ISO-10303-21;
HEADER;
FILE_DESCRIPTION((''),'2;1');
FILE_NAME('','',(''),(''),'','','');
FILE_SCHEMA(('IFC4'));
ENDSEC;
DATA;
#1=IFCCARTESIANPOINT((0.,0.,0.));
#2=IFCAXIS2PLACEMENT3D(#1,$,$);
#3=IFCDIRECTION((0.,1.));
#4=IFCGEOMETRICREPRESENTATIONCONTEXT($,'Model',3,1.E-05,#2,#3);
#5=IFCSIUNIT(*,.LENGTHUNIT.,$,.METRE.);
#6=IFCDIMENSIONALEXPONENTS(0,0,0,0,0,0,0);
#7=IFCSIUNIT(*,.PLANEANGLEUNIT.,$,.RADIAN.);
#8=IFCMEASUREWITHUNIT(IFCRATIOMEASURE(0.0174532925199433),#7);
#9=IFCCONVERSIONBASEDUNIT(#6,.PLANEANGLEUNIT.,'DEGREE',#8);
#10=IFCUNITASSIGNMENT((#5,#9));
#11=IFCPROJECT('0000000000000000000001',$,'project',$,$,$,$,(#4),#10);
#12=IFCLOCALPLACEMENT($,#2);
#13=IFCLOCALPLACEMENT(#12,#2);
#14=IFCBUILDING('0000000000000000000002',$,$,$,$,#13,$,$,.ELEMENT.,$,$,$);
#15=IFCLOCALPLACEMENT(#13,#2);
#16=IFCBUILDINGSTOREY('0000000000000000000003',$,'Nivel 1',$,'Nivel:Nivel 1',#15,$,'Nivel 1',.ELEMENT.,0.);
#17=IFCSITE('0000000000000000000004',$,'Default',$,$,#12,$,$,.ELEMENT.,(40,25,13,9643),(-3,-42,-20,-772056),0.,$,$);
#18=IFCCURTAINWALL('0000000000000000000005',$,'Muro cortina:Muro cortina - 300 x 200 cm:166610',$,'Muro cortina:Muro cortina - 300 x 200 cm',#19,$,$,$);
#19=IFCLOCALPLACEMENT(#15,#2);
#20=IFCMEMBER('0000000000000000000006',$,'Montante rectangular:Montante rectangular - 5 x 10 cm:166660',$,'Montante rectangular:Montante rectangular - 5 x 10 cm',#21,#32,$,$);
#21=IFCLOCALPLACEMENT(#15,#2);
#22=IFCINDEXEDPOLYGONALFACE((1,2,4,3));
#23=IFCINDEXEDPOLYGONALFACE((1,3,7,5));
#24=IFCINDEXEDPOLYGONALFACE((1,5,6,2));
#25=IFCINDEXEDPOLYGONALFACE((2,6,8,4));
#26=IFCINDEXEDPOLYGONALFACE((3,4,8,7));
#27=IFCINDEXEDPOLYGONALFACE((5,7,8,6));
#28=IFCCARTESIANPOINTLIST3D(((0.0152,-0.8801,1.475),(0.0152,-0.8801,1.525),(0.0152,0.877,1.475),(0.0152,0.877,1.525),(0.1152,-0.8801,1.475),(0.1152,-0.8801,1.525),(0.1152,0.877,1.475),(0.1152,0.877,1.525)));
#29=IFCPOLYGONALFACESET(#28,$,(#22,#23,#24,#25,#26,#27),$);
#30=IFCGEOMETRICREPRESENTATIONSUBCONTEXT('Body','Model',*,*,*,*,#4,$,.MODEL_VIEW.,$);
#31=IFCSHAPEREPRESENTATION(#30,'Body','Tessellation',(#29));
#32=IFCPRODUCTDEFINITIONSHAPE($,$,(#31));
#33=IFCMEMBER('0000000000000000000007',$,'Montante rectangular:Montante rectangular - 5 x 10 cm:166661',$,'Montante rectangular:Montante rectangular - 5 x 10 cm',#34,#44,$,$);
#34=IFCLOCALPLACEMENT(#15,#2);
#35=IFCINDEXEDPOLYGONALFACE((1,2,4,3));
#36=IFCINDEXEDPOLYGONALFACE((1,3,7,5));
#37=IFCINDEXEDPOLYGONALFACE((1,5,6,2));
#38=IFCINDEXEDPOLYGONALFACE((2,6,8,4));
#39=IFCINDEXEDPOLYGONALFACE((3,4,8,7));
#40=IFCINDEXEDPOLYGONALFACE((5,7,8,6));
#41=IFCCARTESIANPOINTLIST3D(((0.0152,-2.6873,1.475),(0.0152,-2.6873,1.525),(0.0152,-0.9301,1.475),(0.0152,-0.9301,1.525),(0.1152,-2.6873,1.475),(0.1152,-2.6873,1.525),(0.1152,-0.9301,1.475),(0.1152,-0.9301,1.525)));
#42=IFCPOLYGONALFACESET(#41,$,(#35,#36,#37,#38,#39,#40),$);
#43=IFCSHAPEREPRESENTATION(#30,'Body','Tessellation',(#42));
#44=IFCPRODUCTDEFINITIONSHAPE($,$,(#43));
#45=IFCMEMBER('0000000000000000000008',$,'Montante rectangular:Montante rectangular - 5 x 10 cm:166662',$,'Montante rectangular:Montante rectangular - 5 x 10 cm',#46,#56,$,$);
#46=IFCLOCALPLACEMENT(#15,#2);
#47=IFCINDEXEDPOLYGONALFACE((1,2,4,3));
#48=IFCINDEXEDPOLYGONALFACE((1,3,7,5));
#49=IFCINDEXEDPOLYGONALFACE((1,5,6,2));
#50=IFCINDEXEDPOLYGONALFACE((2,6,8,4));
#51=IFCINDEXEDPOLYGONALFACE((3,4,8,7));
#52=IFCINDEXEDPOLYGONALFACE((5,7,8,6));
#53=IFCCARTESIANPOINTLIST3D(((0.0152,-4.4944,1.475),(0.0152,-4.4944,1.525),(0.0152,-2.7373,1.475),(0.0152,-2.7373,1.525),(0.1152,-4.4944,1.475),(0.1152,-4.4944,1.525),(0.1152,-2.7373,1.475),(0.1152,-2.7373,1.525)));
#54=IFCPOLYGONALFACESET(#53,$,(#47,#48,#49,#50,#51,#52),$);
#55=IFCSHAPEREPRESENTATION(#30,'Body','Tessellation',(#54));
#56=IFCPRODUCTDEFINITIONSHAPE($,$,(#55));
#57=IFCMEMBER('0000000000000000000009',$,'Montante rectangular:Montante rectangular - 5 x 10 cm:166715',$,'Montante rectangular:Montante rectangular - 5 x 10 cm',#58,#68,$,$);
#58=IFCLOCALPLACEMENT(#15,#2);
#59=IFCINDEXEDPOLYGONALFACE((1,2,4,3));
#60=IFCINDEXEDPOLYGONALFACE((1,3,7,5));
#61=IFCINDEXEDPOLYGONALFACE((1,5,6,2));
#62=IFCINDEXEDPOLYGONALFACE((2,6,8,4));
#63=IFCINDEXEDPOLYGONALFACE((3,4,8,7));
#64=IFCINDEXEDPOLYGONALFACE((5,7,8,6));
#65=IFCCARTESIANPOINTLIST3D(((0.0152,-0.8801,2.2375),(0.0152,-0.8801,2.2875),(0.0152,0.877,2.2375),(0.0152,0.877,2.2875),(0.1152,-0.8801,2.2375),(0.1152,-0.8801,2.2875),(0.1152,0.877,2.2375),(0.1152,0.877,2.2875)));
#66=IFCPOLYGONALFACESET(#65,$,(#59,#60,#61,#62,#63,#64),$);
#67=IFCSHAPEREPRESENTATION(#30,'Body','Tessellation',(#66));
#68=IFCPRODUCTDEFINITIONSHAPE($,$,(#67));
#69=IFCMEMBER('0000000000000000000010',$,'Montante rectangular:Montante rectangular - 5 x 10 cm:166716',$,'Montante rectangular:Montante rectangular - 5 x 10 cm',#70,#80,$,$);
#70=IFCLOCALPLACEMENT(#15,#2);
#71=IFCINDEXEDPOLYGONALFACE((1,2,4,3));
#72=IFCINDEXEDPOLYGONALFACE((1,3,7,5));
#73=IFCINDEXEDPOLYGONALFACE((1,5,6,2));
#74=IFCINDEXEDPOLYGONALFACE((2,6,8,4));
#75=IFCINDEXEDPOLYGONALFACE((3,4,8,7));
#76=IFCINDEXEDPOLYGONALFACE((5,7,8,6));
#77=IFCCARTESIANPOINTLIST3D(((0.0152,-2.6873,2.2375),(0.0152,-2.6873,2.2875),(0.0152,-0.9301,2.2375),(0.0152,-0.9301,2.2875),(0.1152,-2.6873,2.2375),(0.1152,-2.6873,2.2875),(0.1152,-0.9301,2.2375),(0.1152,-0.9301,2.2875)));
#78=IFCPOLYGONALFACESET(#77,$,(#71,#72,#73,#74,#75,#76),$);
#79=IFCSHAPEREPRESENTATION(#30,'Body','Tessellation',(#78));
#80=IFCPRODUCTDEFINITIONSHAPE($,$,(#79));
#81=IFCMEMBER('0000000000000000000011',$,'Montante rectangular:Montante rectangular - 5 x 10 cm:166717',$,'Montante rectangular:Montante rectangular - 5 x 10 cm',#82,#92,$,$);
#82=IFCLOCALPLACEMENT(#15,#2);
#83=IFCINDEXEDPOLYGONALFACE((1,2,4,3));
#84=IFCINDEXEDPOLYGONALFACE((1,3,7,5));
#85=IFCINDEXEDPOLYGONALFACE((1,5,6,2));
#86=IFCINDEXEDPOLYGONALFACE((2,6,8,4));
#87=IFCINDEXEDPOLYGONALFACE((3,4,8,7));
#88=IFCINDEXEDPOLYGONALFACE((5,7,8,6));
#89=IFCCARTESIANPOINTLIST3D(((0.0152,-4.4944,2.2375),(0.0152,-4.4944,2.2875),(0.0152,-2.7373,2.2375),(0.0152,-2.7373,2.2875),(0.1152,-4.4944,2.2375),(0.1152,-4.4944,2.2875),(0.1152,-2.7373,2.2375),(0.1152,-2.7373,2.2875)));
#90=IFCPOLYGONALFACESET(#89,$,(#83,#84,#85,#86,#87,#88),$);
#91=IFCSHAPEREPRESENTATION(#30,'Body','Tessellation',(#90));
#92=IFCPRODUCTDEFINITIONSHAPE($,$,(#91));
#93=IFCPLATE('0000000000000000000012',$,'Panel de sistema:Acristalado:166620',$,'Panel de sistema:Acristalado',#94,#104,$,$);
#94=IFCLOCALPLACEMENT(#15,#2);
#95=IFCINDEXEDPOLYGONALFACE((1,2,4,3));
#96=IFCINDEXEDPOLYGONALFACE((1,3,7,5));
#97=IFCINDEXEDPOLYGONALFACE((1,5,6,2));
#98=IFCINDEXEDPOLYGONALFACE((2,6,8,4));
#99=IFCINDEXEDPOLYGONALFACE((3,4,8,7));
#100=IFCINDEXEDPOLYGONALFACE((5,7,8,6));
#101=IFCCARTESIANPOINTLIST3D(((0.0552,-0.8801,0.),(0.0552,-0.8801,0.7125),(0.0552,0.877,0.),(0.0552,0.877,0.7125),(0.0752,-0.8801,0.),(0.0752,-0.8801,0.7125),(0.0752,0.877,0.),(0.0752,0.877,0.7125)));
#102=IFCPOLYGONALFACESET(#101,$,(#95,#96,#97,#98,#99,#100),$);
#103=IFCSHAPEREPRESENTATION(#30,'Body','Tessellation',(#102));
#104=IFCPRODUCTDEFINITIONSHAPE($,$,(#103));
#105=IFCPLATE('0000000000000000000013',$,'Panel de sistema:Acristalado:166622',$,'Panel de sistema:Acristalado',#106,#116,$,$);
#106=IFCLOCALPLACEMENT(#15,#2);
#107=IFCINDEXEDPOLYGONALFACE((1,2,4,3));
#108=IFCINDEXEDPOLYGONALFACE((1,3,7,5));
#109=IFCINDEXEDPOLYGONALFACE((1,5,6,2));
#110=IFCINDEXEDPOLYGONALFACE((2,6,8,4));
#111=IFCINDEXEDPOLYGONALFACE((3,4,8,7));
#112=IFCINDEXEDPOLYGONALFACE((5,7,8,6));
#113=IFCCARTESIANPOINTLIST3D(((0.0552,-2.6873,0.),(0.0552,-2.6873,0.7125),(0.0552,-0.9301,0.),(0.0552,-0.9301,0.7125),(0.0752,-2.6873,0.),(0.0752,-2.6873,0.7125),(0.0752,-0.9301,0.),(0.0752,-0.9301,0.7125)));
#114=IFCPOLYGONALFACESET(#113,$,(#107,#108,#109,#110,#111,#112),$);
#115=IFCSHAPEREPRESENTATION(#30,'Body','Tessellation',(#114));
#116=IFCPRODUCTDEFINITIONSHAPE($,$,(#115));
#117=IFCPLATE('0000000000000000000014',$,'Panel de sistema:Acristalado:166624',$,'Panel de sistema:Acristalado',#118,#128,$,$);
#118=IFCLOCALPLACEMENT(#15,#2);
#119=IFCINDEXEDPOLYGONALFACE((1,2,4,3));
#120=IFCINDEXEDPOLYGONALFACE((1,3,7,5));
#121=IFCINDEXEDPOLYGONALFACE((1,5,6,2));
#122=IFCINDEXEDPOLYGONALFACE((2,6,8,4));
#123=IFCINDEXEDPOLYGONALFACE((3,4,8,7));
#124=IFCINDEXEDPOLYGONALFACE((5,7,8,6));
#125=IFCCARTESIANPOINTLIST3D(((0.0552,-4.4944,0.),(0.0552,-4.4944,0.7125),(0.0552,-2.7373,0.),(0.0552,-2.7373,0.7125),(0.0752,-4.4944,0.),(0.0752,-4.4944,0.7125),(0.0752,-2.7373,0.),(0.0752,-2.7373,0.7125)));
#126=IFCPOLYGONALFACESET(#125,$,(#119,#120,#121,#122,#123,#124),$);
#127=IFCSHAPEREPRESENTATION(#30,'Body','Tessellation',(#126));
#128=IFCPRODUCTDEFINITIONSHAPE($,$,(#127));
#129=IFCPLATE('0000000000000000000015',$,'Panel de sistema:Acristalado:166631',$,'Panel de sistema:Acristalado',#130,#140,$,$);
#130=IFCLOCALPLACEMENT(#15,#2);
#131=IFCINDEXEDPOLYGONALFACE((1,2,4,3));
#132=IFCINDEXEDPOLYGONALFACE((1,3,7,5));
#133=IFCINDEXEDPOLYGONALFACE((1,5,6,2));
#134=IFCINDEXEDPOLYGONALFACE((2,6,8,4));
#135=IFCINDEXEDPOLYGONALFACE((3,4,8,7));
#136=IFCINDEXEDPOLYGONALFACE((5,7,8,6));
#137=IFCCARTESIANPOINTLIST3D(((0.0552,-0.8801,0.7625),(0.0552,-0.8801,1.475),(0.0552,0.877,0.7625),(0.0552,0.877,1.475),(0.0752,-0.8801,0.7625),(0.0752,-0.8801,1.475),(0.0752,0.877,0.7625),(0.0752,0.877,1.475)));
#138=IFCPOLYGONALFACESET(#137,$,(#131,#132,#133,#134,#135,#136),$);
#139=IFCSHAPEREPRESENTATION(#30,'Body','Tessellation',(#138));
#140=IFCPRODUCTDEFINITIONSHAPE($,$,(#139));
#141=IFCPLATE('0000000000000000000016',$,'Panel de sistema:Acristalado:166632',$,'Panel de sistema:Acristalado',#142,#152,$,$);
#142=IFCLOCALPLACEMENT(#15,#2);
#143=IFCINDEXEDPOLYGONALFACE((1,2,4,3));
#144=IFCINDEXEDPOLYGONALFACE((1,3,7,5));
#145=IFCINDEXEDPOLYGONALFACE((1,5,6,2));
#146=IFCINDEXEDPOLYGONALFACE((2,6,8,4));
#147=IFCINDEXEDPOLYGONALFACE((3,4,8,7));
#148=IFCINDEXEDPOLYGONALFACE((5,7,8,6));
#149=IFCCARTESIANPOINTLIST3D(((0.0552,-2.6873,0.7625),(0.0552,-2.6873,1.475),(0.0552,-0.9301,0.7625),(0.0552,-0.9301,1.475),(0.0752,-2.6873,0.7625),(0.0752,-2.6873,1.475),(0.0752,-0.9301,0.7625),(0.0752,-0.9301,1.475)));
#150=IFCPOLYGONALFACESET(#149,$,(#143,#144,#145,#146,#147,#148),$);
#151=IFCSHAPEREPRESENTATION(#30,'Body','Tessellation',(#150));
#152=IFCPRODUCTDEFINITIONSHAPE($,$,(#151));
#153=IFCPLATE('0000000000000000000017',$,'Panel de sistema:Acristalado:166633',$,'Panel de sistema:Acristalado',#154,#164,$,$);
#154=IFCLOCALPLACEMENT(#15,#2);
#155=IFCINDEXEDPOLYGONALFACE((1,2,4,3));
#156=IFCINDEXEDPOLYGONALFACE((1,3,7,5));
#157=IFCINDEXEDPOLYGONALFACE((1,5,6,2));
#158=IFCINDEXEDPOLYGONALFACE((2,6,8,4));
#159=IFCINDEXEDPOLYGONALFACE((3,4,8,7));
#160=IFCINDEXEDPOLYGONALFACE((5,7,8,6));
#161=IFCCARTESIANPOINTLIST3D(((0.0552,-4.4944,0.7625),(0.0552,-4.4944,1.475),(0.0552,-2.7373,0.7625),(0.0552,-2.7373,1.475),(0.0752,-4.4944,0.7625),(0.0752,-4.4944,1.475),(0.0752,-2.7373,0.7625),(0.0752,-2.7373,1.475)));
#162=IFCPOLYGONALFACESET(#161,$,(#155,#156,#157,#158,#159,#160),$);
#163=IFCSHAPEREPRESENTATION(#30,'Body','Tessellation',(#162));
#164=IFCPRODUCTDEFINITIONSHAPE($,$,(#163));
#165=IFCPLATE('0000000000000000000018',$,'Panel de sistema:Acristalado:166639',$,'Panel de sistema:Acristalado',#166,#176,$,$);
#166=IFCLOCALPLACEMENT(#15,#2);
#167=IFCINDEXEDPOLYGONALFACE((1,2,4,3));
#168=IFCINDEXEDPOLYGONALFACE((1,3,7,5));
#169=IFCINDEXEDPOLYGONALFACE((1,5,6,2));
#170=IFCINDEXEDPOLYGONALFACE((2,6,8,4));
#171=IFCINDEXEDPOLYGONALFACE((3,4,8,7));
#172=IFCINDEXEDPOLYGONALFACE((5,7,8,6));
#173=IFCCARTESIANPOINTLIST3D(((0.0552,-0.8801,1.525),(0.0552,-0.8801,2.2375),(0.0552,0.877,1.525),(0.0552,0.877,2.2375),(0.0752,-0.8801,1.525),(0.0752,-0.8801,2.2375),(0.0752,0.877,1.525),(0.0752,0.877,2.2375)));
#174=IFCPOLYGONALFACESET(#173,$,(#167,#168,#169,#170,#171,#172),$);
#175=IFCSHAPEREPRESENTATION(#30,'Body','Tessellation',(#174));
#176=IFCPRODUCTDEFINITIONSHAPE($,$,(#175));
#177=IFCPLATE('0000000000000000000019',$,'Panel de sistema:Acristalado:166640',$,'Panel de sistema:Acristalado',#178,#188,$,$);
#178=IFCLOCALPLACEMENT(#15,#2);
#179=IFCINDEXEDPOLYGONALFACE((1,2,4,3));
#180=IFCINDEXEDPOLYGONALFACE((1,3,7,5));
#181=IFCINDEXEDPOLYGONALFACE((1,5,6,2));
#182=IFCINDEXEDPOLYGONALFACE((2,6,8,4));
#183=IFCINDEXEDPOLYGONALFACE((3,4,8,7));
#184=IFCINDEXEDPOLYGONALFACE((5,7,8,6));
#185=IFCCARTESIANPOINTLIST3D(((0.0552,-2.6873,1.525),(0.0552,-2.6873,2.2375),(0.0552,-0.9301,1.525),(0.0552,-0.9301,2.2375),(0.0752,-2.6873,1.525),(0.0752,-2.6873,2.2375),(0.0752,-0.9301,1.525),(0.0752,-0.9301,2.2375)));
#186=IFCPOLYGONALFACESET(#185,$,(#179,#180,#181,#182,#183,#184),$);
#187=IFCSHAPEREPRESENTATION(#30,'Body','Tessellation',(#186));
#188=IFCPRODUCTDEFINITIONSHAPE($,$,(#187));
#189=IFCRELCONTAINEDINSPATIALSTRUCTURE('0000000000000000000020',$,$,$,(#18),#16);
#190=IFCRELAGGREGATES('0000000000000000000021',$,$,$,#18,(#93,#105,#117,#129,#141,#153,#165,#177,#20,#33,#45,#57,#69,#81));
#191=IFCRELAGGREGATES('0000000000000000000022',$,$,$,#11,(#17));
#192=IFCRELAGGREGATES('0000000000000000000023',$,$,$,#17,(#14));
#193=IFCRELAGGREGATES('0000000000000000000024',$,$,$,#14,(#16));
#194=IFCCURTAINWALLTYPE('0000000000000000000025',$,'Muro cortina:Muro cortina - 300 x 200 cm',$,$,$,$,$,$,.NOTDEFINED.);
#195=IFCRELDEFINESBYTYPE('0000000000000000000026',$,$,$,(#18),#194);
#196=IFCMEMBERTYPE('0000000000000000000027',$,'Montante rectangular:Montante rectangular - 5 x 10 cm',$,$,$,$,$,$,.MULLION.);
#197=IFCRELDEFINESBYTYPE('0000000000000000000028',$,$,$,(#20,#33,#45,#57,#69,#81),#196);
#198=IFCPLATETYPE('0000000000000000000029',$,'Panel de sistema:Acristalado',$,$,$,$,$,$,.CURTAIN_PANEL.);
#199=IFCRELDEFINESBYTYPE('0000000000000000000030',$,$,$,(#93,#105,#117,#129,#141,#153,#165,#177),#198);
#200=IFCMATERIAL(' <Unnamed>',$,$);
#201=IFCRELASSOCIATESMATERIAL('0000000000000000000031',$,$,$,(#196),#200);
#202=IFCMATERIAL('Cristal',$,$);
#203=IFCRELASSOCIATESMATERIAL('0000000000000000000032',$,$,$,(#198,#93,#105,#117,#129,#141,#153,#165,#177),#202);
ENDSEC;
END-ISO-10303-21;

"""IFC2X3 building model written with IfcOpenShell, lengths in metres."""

from ifc_helpers import new_model, entity, si_unit, converted_unit, direction, frame, origin, origin_2d_with_axis, place, context, subcontext, project, spatial, rectangle, extrude, source, transform, mapped, material, type_object, type_shapes, element, aggregate, save


model = new_model("IFC2X3")

# Units and contexts
model_context = context("Model", 3, precision=1e-05, world=origin(), true_north=direction((0.0, 1.0)))
body_context = subcontext(model_context, "Body", "Model", "MODEL_VIEW")
ifc_project = project(units=[si_unit("LENGTHUNIT", "METRE"), converted_unit("PLANEANGLEUNIT", "DEGREE", entity("IfcRatioMeasure", 0.0174532925199433), si_unit("PLANEANGLEUNIT", "RADIAN"), dimensions=[0, 0, 0, 0, 0, 0, 0])], contexts=[model_context])

# Site, building, storey
site_placement = place(None, origin())
site = spatial("IfcSite", under=ifc_project, at=site_placement, Name="Default", CompositionType="ELEMENT", RefLatitude=(40, 25, 13, 9643), RefLongitude=(-3, -42, -20, -772056), RefElevation=0.0)
building_placement = place(site_placement, origin())
building = spatial("IfcBuilding", under=site, at=building_placement, CompositionType="ELEMENT")
storey_placement = place(building_placement, origin())
storey = spatial("IfcBuildingStorey", under=building, at=storey_placement, Name="Nivel 1", ObjectType="Nivel:Nivel 1", LongName="Nivel 1", CompositionType="ELEMENT", Elevation=0.0)

# Curtain wall, members, plates
curtain_wall_type = type_object("IfcCurtainWallType", Name="Muro cortina:Muro cortina - 300 x 200 cm", PredefinedType="NOTDEFINED")
curtain_wall_placement = place(storey_placement, origin())
curtain_wall = element("IfcCurtainWall", 1, at=curtain_wall_placement, inside=storey, type_object=curtain_wall_type, Name="Muro cortina:Muro cortina - 300 x 200 cm:166610", ObjectType="Muro cortina:Muro cortina - 300 x 200 cm")
ifc_material_1 = material(Name=" <Unnamed>")
member_type_1 = type_object("IfcMemberType", Name="Montante rectangular:Montante rectangular - 5 x 10 cm", PredefinedType="MULLION", material=ifc_material_1)
shared_shape_1 = source(origin(), body_context, "Body", "SweptSolid", [
    extrude(rectangle(XDim=0.1, YDim=0.05, at=origin_2d_with_axis()), frame((0.0, 0.0, -1.7571), z_axis=(0.0, 0.0, 1.0), x_axis=(0.0, -1.0, 0.0)), (0.0, 0.0, 1.0), 1.7571),
])
type_shapes(member_type_1, [shared_shape_1])
member_1_placement = place(storey_placement, frame((0.0652, -0.8801, 1.5), z_axis=(0.0, -1.0, 0.0), x_axis=(0.0, 0.0, 1.0)))
member_1 = element("IfcMember", 2, at=member_1_placement, type_object=member_type_1, Name="Montante rectangular:Montante rectangular - 5 x 10 cm:166660", ObjectType="Montante rectangular:Montante rectangular - 5 x 10 cm", context=body_context, shape_type="MappedRepresentation", body=[
    mapped(shared_shape_1, transform((0.0, 0.0, 0.0), scale=1.0)),
])
member_2_placement = place(storey_placement, frame((0.0652, -2.6873, 1.5), z_axis=(0.0, -1.0, 0.0), x_axis=(0.0, 0.0, 1.0)))
member_2 = element("IfcMember", 3, at=member_2_placement, type_object=member_type_1, Name="Montante rectangular:Montante rectangular - 5 x 10 cm:166661", ObjectType="Montante rectangular:Montante rectangular - 5 x 10 cm", context=body_context, shape_type="MappedRepresentation", body=[
    mapped(shared_shape_1, transform((0.0, 0.0, 0.0), scale=1.0)),
])
member_3_placement = place(storey_placement, frame((0.0652, -4.4944, 1.5), z_axis=(0.0, -1.0, 0.0), x_axis=(0.0, 0.0, 1.0)))
member_3 = element("IfcMember", 4, at=member_3_placement, type_object=member_type_1, Name="Montante rectangular:Montante rectangular - 5 x 10 cm:166662", ObjectType="Montante rectangular:Montante rectangular - 5 x 10 cm", context=body_context, shape_type="MappedRepresentation", body=[
    mapped(shared_shape_1, transform((0.0, 0.0, 0.0), scale=1.0)),
])
member_4_placement = place(storey_placement, frame((0.0652, -0.8801, 2.2625), z_axis=(0.0, -1.0, 0.0), x_axis=(0.0, 0.0, 1.0)))
member_4 = element("IfcMember", 5, at=member_4_placement, type_object=member_type_1, Name="Montante rectangular:Montante rectangular - 5 x 10 cm:166715", ObjectType="Montante rectangular:Montante rectangular - 5 x 10 cm", context=body_context, shape_type="MappedRepresentation", body=[
    mapped(shared_shape_1, transform((0.0, 0.0, 0.0), scale=1.0)),
])
member_5_placement = place(storey_placement, frame((0.0652, -2.6873, 2.2625), z_axis=(0.0, -1.0, 0.0), x_axis=(0.0, 0.0, 1.0)))
member_5 = element("IfcMember", 6, at=member_5_placement, type_object=member_type_1, Name="Montante rectangular:Montante rectangular - 5 x 10 cm:166716", ObjectType="Montante rectangular:Montante rectangular - 5 x 10 cm", context=body_context, shape_type="MappedRepresentation", body=[
    mapped(shared_shape_1, transform((0.0, 0.0, 0.0), scale=1.0)),
])
member_6_placement = place(storey_placement, frame((0.0652, -4.4944, 2.2625), z_axis=(0.0, -1.0, 0.0), x_axis=(0.0, 0.0, 1.0)))
member_6 = element("IfcMember", 7, at=member_6_placement, type_object=member_type_1, Name="Montante rectangular:Montante rectangular - 5 x 10 cm:166717", ObjectType="Montante rectangular:Montante rectangular - 5 x 10 cm", context=body_context, shape_type="MappedRepresentation", body=[
    mapped(shared_shape_1, transform((0.0, 0.0, 0.0), scale=1.0)),
])
ifc_material_2 = material(Name="Cristal")
plate_type = type_object("IfcPlateType", Name="Panel de sistema:Acristalado", PredefinedType="CURTAIN_PANEL", material=ifc_material_2)
shared_shape_2 = source(origin(), body_context, "Body", "SweptSolid", [
    extrude(rectangle(XDim=0.02, YDim=1.7571, at=origin_2d_with_axis()), frame((0.0, 0.0, 0.0), z_axis=(0.0, 0.0, 1.0), x_axis=(0.0, 1.0, 0.0)), (0.0, 0.0, 1.0), 0.7125),
])
type_shapes(plate_type, [shared_shape_2])
plate_1_placement = place(curtain_wall_placement, frame((0.0652, -0.0015, 0.0), z_axis=(0.0, 0.0, 1.0), x_axis=(0.0, -1.0, 0.0)))
plate_1 = element("IfcPlate", 8, at=plate_1_placement, type_object=plate_type, material=ifc_material_2, Name="Panel de sistema:Acristalado:166620", ObjectType="Panel de sistema:Acristalado", context=body_context, shape_type="MappedRepresentation", body=[
    mapped(shared_shape_2, transform((0.0, 0.0, 0.0), scale=1.0)),
])
plate_2_placement = place(curtain_wall_placement, frame((0.0652, -1.8087, 0.0), z_axis=(0.0, 0.0, 1.0), x_axis=(0.0, -1.0, 0.0)))
plate_2 = element("IfcPlate", 9, at=plate_2_placement, type_object=plate_type, material=ifc_material_2, Name="Panel de sistema:Acristalado:166622", ObjectType="Panel de sistema:Acristalado", context=body_context, shape_type="MappedRepresentation", body=[
    mapped(shared_shape_2, transform((0.0, 0.0, 0.0), scale=1.0)),
])
plate_3_placement = place(curtain_wall_placement, frame((0.0652, -3.6158, 0.0), z_axis=(0.0, 0.0, 1.0), x_axis=(0.0, -1.0, 0.0)))
plate_3 = element("IfcPlate", 10, at=plate_3_placement, type_object=plate_type, material=ifc_material_2, Name="Panel de sistema:Acristalado:166624", ObjectType="Panel de sistema:Acristalado", context=body_context, shape_type="MappedRepresentation", body=[
    mapped(shared_shape_2, transform((0.0, 0.0, 0.0), scale=1.0)),
])
plate_4_placement = place(curtain_wall_placement, frame((0.0652, -0.0015, 0.7625), z_axis=(0.0, 0.0, 1.0), x_axis=(0.0, -1.0, 0.0)))
plate_4 = element("IfcPlate", 11, at=plate_4_placement, type_object=plate_type, material=ifc_material_2, Name="Panel de sistema:Acristalado:166631", ObjectType="Panel de sistema:Acristalado", context=body_context, shape_type="MappedRepresentation", body=[
    mapped(shared_shape_2, transform((0.0, 0.0, 0.0), scale=1.0)),
])
plate_5_placement = place(curtain_wall_placement, frame((0.0652, -1.8087, 0.7625), z_axis=(0.0, 0.0, 1.0), x_axis=(0.0, -1.0, 0.0)))
plate_5 = element("IfcPlate", 12, at=plate_5_placement, type_object=plate_type, material=ifc_material_2, Name="Panel de sistema:Acristalado:166632", ObjectType="Panel de sistema:Acristalado", context=body_context, shape_type="MappedRepresentation", body=[
    mapped(shared_shape_2, transform((0.0, 0.0, 0.0), scale=1.0)),
])
plate_6_placement = place(curtain_wall_placement, frame((0.0652, -3.6158, 0.7625), z_axis=(0.0, 0.0, 1.0), x_axis=(0.0, -1.0, 0.0)))
plate_6 = element("IfcPlate", 13, at=plate_6_placement, type_object=plate_type, material=ifc_material_2, Name="Panel de sistema:Acristalado:166633", ObjectType="Panel de sistema:Acristalado", context=body_context, shape_type="MappedRepresentation", body=[
    mapped(shared_shape_2, transform((0.0, 0.0, 0.0), scale=1.0)),
])
plate_7_placement = place(curtain_wall_placement, frame((0.0652, -0.0015, 1.525), z_axis=(0.0, 0.0, 1.0), x_axis=(0.0, -1.0, 0.0)))
plate_7 = element("IfcPlate", 14, at=plate_7_placement, type_object=plate_type, material=ifc_material_2, Name="Panel de sistema:Acristalado:166639", ObjectType="Panel de sistema:Acristalado", context=body_context, shape_type="MappedRepresentation", body=[
    mapped(shared_shape_2, transform((0.0, 0.0, 0.0), scale=1.0)),
])
plate_8_placement = place(curtain_wall_placement, frame((0.0652, -1.8087, 1.525), z_axis=(0.0, 0.0, 1.0), x_axis=(0.0, -1.0, 0.0)))
plate_8 = element("IfcPlate", 15, at=plate_8_placement, type_object=plate_type, material=ifc_material_2, Name="Panel de sistema:Acristalado:166640", ObjectType="Panel de sistema:Acristalado", context=body_context, shape_type="MappedRepresentation", body=[
    mapped(shared_shape_2, transform((0.0, 0.0, 0.0), scale=1.0)),
])
aggregate(curtain_wall, [plate_1, plate_2, plate_3, plate_4, plate_5, plate_6, plate_7, plate_8, member_1, member_2, member_3, member_4, member_5, member_6])

save(model, "model.ifc")
